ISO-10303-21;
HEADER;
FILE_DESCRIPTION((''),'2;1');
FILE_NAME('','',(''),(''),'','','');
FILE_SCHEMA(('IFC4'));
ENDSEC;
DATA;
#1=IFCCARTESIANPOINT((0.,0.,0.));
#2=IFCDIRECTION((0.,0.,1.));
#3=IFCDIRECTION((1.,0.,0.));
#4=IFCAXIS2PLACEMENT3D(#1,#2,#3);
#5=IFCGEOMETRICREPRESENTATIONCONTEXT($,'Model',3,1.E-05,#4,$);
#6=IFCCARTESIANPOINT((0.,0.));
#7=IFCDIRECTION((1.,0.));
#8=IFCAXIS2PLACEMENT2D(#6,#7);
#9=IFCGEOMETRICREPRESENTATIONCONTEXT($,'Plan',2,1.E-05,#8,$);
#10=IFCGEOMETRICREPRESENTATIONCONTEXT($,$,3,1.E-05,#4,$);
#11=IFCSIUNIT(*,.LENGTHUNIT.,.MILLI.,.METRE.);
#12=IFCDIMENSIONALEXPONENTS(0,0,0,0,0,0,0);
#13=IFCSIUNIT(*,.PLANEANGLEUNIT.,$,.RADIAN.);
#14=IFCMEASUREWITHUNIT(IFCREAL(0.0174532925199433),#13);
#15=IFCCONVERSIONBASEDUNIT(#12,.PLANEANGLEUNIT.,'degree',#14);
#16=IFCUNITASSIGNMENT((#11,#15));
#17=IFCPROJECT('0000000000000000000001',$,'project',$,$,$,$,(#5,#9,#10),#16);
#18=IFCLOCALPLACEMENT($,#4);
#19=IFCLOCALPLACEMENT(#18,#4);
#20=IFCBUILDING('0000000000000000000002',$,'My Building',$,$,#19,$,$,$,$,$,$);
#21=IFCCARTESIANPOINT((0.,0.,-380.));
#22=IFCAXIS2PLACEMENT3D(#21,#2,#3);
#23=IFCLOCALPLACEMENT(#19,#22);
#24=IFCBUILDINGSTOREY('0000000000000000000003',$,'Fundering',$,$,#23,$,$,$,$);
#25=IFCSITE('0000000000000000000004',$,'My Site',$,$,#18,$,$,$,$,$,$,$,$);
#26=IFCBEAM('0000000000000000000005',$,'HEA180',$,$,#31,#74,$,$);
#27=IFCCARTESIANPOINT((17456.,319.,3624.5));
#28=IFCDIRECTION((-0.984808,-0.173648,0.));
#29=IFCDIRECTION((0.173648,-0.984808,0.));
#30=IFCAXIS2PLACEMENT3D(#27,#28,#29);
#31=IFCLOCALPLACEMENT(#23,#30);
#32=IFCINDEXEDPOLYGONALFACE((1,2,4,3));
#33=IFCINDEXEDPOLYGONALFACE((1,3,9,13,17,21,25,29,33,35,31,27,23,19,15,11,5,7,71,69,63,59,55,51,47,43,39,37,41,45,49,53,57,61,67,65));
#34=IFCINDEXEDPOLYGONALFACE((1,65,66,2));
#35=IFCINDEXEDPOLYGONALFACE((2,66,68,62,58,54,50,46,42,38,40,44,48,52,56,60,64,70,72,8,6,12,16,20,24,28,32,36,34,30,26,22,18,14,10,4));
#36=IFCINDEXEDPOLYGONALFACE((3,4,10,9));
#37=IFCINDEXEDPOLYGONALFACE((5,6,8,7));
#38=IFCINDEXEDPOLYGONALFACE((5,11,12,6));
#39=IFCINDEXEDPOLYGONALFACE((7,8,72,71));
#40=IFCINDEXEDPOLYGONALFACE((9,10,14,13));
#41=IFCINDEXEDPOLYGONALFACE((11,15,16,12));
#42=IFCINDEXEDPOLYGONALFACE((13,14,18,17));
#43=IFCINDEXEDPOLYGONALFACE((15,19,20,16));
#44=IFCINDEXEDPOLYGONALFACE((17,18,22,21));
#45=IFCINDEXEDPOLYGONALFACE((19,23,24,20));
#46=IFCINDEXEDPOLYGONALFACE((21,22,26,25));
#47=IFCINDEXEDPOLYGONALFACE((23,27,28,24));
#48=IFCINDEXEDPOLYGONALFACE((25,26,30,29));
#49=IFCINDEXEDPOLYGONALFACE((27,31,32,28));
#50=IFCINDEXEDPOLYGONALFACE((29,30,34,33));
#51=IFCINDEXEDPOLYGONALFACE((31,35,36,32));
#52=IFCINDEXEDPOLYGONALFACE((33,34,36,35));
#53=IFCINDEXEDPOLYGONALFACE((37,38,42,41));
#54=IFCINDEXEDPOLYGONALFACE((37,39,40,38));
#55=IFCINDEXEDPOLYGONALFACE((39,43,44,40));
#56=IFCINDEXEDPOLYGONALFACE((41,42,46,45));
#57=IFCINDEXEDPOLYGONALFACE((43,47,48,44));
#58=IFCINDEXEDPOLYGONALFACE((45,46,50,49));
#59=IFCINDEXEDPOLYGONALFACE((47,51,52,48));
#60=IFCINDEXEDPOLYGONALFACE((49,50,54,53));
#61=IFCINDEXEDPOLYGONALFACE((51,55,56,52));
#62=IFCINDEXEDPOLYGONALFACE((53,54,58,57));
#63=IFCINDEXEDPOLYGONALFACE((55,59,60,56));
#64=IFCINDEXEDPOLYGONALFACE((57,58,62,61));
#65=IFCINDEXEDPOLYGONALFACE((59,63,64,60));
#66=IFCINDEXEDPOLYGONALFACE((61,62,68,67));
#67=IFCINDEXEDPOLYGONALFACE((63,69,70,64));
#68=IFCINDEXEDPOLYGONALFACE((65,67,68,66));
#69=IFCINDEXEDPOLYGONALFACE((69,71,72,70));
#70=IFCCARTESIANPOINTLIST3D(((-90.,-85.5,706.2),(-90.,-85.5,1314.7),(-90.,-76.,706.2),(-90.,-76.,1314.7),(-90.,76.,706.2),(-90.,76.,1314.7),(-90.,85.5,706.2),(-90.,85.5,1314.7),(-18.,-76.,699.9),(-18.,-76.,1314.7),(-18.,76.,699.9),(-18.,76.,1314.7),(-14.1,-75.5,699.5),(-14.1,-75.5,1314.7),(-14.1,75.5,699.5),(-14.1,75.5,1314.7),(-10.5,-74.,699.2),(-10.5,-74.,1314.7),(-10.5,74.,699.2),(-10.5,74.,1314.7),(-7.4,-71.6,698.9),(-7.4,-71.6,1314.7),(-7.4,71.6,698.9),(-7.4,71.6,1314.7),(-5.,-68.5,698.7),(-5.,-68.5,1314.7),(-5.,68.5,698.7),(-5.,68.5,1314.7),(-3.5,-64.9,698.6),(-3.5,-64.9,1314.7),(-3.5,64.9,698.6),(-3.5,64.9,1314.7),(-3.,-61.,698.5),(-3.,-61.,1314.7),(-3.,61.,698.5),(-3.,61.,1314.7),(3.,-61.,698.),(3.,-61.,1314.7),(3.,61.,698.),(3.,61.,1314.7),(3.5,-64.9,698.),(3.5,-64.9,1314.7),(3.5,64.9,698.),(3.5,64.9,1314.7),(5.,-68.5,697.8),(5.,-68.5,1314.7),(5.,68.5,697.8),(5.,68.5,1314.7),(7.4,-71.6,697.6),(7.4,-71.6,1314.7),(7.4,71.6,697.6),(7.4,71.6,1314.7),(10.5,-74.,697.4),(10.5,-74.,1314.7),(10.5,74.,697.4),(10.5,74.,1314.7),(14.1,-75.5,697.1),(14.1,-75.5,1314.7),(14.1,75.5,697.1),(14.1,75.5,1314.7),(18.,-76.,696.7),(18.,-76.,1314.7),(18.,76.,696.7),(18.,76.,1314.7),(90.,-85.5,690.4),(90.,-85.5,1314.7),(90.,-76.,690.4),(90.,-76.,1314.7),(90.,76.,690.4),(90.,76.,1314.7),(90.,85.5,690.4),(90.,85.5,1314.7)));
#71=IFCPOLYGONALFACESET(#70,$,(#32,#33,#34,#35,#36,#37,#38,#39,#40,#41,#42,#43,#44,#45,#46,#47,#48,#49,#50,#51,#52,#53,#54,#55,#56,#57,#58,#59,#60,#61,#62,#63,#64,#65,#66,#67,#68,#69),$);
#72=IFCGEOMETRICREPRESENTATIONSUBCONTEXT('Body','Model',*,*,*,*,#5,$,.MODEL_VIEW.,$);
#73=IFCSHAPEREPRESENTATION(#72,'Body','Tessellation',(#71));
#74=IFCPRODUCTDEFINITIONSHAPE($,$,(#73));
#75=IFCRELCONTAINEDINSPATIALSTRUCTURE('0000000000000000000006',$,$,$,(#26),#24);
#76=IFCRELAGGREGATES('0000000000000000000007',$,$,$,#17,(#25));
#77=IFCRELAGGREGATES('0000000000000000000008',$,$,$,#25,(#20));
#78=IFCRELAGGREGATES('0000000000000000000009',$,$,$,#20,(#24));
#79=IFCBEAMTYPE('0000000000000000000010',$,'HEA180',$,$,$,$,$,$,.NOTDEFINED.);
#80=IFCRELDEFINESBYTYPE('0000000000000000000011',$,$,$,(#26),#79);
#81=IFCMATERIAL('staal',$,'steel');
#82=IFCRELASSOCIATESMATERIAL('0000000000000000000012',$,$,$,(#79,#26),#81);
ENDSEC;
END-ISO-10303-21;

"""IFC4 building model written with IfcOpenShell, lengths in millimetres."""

from ifc_helpers import new_model, entity, si_unit, converted_unit, frame, origin_with_axes, origin_2d_with_axis, place, context, subcontext, project, spatial, i_section, extrude, clip, halfspace, material, material_profile, profile_set, profile_usage, type_object, element, save


model = new_model("IFC4")

# Units and contexts
model_context = context("Model", 3, precision=1e-05, world=origin_with_axes())
plan_context = context("Plan", 2, precision=1e-05, world=origin_2d_with_axis())
context_of_model = context(None, 3, precision=1e-05, world=origin_with_axes())
body_context = subcontext(model_context, "Body", "Model", "MODEL_VIEW")
ifc_project = project(units=[si_unit("LENGTHUNIT", "METRE", prefix="MILLI"), converted_unit("PLANEANGLEUNIT", "degree", entity("IfcReal", 0.0174532925199433), si_unit("PLANEANGLEUNIT", "RADIAN"), dimensions=[0, 0, 0, 0, 0, 0, 0])], contexts=[model_context, plan_context, context_of_model])

# Site, building, storey
site_placement = place(None, origin_with_axes())
site = spatial("IfcSite", under=ifc_project, at=site_placement, Name="My Site")
building_placement = place(site_placement, origin_with_axes())
building = spatial("IfcBuilding", under=site, at=building_placement, Name="My Building")
storey_placement = place(building_placement, frame((0.0, 0.0, -380.0), z_axis=(0.0, 0.0, 1.0), x_axis=(1.0, 0.0, 0.0)))
storey = spatial("IfcBuildingStorey", under=building, at=storey_placement, Name="Fundering")

# Shared definitions
ifc_material_1 = material(Name="staal", Category="steel")

# Beam
ifc_material_profile_1 = material_profile(ifc_material_1, i_section(OverallWidth=180.0, OverallDepth=171.0, WebThickness=6.0, FlangeThickness=9.5, FilletRadius=15.0))
ifc_profile_set_1 = profile_set([ifc_material_profile_1], Name="HEA180")
beam_type_1 = type_object("IfcBeamType", Name="HEA180", PredefinedType="NOTDEFINED", material=ifc_profile_set_1)
ifc_profile_usage_1 = profile_usage(ifc_profile_set_1)
beam_1_placement = place(storey_placement, frame((17456.0, 319.0, 3624.5), z_axis=(-0.984808, -0.173648, 0.0), x_axis=(0.173648, -0.984808, 0.0)))
element("IfcBeam", 1, at=beam_1_placement, inside=storey, type_object=beam_type_1, material=ifc_profile_usage_1, Name="HEA180", context=body_context, shape_type="Clipping", body=[
    clip(extrude(i_section(OverallWidth=180.0, OverallDepth=171.0, WebThickness=6.0, FlangeThickness=9.5, FilletRadius=15.0), origin_with_axes(), (0.0, 0.0, 1.0), 1314.7), halfspace(frame((90.0, -3244.5, 690.4), z_axis=(-0.087167, 0.0, -0.996194), x_axis=(-0.000001, 1.0, 0.0)), False)),
])

save(model, "model.ifc")
